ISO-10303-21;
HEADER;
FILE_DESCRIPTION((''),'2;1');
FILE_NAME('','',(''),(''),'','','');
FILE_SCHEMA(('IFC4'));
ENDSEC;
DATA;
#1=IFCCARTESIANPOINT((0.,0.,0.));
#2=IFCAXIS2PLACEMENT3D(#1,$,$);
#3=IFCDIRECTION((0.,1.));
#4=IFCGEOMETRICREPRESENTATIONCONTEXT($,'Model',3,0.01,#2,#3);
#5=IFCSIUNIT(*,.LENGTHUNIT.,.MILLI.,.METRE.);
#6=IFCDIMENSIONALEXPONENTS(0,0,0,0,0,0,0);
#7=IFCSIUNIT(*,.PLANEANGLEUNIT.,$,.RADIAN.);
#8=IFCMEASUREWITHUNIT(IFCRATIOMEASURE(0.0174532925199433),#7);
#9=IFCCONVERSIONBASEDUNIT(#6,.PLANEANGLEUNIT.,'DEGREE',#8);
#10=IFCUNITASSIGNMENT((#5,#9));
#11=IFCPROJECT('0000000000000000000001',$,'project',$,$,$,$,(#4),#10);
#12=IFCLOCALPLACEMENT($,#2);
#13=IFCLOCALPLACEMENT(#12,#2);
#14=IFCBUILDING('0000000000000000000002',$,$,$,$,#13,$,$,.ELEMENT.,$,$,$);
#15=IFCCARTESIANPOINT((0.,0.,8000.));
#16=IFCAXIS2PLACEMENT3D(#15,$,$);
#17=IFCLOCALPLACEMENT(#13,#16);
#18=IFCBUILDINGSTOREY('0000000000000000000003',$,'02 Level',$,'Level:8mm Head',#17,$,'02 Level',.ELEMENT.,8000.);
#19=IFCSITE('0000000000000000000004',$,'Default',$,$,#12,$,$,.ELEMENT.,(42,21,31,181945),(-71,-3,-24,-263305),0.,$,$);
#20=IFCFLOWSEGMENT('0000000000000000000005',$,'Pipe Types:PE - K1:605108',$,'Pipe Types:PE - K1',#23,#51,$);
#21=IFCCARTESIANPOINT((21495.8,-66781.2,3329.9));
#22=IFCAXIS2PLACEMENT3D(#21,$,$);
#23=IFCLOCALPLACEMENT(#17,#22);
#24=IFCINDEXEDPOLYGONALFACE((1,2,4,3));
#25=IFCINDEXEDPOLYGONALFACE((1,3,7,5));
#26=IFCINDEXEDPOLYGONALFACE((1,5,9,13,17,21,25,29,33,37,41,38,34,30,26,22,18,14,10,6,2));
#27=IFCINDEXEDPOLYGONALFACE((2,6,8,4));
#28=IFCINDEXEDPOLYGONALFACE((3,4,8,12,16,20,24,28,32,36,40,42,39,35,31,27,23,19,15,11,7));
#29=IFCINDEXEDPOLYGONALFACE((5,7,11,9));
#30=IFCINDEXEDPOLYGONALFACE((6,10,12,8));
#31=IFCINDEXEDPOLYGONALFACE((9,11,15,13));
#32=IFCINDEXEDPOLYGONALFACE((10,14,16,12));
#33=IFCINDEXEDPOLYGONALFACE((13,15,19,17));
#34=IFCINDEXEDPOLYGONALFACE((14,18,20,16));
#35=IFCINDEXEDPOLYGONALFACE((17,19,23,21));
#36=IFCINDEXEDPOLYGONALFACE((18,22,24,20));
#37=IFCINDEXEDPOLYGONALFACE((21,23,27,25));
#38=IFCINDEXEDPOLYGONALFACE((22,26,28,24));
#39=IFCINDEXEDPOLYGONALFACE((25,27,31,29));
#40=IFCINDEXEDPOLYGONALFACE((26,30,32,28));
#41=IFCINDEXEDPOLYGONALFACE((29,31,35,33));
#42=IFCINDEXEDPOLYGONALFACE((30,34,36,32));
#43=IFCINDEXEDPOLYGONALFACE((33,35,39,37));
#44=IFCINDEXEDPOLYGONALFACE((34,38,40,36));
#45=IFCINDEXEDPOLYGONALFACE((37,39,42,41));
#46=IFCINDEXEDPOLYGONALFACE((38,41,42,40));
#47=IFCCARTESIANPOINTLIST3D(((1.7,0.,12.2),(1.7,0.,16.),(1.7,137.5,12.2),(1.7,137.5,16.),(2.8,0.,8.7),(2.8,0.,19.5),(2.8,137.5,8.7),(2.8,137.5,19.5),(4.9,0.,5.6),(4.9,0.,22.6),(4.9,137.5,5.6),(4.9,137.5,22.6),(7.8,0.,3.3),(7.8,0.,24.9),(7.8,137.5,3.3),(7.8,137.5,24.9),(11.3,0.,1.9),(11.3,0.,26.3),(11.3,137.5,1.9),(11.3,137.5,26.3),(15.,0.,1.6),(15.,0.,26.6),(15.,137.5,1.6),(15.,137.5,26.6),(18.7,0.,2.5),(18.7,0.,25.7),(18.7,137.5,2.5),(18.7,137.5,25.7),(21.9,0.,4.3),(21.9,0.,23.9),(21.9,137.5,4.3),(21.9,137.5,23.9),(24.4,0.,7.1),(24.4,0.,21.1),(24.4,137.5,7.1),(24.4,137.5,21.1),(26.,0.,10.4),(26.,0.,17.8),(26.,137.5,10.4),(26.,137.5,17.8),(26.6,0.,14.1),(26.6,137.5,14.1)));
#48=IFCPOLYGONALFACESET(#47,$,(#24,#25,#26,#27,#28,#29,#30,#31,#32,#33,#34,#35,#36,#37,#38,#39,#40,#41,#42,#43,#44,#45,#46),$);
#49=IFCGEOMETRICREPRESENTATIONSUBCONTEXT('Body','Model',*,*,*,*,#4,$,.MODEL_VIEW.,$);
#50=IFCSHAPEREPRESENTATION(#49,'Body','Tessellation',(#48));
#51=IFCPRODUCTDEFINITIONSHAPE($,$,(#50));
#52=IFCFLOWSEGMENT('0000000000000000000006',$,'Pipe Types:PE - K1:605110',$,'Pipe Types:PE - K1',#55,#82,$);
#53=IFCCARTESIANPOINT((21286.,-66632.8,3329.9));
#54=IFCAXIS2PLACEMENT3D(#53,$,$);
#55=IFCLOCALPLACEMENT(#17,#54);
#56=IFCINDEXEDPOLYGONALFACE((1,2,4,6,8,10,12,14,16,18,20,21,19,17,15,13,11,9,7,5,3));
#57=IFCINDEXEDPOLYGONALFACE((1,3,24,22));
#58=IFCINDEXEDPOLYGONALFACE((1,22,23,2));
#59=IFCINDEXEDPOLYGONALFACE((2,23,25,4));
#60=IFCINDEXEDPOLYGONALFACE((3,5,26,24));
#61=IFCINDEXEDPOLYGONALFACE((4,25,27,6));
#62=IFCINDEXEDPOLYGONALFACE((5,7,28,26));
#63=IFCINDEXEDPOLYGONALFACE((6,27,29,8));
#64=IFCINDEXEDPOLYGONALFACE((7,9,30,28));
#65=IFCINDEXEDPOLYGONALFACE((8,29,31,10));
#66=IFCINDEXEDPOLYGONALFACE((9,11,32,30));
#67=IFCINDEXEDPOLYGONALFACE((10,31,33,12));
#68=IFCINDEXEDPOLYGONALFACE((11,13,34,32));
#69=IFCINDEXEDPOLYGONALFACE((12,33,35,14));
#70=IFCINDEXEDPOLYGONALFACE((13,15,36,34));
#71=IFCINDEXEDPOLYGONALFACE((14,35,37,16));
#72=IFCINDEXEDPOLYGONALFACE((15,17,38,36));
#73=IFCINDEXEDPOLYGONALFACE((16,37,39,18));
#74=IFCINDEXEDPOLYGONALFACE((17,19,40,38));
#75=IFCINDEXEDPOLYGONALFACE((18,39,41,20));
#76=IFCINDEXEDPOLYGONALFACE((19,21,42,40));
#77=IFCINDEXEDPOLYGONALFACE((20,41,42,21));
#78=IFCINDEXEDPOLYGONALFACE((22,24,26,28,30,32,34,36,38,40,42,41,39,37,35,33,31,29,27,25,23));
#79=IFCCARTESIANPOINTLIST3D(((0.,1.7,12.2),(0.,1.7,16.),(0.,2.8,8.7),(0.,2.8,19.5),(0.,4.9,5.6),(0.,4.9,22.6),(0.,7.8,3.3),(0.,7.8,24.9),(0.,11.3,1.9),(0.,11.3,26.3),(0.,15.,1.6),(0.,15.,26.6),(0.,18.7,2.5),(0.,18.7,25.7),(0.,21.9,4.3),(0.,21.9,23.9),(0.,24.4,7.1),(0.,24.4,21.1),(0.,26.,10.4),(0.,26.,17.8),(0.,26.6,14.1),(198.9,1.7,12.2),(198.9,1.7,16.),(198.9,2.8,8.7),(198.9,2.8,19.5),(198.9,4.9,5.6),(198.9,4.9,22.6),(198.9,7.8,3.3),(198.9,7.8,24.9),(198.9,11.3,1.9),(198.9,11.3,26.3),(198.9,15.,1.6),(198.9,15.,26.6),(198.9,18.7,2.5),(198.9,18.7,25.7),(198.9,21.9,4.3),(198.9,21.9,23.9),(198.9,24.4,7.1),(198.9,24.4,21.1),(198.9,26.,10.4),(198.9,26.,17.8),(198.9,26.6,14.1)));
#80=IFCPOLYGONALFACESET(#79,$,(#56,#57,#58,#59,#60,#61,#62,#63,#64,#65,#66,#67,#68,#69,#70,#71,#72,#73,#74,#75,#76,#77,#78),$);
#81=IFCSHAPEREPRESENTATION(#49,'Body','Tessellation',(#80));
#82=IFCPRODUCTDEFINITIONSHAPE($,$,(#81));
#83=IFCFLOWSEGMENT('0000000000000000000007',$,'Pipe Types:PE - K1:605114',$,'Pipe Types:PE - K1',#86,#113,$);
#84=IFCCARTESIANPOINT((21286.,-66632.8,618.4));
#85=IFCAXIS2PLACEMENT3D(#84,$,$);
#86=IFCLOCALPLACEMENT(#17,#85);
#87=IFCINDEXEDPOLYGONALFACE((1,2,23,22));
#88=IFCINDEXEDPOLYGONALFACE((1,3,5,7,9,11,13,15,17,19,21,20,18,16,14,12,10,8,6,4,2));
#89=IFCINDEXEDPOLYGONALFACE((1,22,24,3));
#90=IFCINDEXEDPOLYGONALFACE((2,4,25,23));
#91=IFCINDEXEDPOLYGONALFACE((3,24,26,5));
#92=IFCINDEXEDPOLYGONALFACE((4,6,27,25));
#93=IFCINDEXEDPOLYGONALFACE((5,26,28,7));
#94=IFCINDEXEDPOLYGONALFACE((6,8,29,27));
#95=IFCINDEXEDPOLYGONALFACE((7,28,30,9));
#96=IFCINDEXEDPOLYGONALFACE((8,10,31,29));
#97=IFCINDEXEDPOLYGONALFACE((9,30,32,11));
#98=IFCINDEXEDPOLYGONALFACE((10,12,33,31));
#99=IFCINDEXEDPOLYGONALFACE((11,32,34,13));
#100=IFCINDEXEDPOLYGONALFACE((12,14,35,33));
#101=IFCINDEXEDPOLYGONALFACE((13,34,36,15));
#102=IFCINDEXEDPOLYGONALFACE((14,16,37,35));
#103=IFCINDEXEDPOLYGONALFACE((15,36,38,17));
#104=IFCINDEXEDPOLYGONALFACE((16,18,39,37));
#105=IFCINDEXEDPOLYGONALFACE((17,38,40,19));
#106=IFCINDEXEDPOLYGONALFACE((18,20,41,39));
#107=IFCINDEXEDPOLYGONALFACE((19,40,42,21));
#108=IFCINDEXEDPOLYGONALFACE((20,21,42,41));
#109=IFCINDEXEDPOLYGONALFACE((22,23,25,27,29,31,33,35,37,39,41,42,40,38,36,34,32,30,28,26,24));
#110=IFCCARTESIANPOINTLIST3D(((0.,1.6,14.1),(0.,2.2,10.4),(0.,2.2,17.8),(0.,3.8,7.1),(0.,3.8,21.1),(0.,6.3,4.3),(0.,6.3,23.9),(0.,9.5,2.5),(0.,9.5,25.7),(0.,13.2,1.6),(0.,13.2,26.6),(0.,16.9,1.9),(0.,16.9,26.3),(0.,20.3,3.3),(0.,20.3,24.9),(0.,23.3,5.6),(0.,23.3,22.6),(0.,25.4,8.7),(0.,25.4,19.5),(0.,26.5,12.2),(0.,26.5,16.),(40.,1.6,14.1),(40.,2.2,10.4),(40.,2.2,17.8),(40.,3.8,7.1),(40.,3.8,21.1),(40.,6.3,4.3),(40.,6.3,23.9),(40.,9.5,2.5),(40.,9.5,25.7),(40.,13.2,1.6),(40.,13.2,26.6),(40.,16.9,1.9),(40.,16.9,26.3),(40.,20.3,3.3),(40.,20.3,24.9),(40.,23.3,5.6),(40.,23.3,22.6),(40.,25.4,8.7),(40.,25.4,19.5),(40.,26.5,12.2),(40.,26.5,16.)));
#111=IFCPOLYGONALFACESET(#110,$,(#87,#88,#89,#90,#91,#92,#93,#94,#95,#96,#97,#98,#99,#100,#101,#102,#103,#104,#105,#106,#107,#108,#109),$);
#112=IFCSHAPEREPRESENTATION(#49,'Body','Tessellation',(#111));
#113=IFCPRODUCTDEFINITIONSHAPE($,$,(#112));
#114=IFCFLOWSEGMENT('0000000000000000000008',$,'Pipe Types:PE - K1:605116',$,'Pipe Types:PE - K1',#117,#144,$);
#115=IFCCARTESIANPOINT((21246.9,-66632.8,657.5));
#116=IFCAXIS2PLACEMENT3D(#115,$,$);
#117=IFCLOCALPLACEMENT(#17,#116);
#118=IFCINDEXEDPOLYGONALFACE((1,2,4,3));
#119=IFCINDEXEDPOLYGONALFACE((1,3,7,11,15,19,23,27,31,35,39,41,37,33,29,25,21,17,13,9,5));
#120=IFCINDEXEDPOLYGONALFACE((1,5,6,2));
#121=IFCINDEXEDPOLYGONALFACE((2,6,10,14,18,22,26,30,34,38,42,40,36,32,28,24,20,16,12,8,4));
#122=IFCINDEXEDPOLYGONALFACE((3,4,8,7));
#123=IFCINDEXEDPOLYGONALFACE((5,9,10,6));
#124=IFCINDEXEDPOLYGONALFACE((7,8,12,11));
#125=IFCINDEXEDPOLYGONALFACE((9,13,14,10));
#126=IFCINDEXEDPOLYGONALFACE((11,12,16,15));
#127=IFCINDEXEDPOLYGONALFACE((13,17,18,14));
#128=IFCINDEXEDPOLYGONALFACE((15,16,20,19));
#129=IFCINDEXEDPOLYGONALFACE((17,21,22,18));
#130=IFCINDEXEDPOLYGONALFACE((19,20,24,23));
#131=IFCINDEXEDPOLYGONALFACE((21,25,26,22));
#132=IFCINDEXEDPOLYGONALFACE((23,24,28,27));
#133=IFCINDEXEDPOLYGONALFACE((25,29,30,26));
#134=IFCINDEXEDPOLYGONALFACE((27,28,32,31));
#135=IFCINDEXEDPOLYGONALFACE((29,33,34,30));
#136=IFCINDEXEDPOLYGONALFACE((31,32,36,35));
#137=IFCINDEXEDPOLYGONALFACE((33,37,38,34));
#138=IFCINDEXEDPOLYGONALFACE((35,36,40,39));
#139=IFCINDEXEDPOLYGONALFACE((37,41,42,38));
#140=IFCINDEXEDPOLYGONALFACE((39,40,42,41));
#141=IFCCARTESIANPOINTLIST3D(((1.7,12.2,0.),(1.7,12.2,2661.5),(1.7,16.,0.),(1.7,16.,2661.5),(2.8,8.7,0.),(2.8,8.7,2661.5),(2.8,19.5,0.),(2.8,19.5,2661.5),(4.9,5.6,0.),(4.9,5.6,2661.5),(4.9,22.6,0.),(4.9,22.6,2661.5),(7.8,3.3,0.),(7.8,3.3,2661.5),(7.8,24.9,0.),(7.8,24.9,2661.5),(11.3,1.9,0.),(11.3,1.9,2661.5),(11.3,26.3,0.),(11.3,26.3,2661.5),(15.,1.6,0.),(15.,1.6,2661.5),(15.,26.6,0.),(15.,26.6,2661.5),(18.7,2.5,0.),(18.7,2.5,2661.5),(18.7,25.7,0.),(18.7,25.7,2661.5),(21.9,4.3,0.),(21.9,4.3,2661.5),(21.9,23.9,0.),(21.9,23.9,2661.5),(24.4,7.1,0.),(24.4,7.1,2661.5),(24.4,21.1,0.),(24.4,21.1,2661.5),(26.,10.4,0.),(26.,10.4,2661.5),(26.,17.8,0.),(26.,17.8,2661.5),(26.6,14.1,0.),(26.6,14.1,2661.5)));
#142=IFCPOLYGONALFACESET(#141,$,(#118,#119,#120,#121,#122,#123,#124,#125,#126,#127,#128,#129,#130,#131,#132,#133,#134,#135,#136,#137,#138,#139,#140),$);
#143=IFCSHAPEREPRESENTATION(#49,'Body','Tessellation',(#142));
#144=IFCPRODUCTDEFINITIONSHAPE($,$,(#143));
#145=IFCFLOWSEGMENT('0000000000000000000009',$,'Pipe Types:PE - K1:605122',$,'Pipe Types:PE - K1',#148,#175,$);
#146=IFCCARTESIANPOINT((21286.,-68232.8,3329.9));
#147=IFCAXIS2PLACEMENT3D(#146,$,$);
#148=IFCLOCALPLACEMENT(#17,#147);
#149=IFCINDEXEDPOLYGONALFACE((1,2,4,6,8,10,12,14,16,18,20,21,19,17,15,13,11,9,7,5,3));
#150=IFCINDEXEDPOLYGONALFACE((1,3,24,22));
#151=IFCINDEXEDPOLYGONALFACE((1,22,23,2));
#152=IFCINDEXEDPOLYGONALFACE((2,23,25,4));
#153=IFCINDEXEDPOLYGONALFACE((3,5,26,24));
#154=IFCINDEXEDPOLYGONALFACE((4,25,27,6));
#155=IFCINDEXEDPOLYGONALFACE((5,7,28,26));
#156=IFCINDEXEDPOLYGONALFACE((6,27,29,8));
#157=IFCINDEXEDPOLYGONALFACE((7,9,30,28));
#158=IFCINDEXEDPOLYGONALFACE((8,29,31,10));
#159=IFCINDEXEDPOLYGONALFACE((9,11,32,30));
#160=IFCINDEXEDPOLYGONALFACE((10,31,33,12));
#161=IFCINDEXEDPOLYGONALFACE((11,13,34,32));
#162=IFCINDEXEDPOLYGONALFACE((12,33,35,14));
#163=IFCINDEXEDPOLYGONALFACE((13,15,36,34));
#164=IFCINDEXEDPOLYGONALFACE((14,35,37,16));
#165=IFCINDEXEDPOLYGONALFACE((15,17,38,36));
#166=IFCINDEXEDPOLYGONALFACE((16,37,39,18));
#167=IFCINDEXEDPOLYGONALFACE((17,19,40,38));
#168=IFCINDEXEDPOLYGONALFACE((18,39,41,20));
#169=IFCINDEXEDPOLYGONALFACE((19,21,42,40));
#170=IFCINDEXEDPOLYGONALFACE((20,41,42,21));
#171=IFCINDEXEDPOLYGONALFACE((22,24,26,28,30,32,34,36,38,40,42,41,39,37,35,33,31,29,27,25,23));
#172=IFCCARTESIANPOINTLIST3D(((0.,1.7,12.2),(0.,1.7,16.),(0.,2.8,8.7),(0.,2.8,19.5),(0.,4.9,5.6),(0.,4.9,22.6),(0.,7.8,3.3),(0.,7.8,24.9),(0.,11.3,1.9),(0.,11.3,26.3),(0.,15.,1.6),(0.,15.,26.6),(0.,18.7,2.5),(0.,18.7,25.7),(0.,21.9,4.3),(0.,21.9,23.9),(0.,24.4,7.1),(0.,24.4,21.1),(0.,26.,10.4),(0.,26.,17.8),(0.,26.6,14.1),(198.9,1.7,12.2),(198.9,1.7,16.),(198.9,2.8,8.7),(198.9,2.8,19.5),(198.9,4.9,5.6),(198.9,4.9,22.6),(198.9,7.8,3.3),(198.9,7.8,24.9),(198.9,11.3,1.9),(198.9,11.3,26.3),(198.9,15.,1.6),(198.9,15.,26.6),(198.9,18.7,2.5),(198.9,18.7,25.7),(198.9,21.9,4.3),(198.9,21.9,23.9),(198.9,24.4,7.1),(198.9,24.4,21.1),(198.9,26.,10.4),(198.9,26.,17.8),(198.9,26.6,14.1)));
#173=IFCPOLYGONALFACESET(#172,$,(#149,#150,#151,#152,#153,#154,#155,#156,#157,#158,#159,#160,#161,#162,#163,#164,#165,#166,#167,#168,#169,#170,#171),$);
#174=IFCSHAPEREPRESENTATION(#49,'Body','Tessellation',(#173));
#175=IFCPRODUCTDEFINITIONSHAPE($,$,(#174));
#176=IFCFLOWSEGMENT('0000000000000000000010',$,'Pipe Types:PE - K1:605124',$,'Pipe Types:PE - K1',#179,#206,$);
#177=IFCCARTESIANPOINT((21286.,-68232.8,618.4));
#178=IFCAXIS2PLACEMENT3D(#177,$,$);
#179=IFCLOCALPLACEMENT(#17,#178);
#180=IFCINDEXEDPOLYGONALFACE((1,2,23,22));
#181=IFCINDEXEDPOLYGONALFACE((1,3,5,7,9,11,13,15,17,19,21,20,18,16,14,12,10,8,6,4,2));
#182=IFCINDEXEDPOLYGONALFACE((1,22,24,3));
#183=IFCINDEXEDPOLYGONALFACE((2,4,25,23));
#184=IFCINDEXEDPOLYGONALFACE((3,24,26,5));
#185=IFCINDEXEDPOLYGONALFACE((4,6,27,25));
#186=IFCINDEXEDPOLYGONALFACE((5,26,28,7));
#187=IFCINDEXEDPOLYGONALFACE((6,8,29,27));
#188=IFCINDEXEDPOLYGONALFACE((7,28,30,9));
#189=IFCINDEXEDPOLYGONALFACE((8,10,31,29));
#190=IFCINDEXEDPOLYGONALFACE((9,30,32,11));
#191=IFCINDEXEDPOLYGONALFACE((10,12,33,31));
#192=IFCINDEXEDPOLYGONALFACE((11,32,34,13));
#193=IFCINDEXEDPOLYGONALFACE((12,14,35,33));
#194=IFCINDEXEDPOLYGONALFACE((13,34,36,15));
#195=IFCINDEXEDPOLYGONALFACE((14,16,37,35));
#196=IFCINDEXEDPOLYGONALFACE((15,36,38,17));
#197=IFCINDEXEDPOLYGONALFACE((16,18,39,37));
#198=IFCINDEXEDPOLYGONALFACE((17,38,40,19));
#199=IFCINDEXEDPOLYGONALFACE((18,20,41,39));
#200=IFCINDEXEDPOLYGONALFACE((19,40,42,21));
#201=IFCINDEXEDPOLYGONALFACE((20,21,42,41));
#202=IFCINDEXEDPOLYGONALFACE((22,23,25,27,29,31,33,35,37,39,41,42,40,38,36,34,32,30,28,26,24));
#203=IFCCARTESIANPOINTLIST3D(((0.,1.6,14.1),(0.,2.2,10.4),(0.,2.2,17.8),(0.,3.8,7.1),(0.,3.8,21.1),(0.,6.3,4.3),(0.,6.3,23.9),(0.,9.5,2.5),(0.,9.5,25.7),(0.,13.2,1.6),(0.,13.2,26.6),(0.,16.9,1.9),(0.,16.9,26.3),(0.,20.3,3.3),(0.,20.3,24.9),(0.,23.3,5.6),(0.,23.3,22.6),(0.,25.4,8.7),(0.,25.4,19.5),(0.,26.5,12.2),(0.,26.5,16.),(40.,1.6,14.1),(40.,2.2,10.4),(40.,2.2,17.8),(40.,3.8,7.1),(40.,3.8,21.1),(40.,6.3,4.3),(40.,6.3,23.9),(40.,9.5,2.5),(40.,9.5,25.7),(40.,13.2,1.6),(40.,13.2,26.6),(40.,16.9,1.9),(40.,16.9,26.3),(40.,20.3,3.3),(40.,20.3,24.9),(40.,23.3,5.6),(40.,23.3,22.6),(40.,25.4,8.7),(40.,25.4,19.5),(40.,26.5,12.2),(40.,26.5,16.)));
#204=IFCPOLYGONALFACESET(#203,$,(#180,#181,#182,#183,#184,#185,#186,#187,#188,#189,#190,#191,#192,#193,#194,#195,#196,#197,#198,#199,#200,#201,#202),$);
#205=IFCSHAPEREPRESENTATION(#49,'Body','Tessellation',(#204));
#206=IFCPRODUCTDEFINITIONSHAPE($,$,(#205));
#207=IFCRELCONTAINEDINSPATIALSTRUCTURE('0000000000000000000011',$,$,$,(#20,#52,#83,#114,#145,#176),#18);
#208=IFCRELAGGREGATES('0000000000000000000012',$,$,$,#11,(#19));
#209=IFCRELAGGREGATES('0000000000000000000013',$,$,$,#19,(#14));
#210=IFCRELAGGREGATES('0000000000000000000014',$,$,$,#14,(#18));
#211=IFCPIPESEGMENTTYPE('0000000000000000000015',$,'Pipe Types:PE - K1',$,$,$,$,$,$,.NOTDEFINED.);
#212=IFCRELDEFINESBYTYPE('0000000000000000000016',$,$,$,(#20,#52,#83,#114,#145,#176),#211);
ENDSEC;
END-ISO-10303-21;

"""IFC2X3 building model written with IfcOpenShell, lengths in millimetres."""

from ifc_helpers import new_model, entity, si_unit, converted_unit, direction, frame, frame_2d, origin, origin_2d_with_axis, place, context, subcontext, project, spatial, circle, extrude, type_object, element, save


model = new_model("IFC2X3")

# Units and contexts
model_context = context("Model", 3, precision=0.01, world=origin(), true_north=direction((0.0, 1.0)))
body_context = subcontext(model_context, "Body", "Model", "MODEL_VIEW")
ifc_project = project(units=[si_unit("LENGTHUNIT", "METRE", prefix="MILLI"), converted_unit("PLANEANGLEUNIT", "DEGREE", entity("IfcRatioMeasure", 0.0174532925199433), si_unit("PLANEANGLEUNIT", "RADIAN"), dimensions=[0, 0, 0, 0, 0, 0, 0])], contexts=[model_context])

# Site, building, storey
site_placement = place(None, origin())
site = spatial("IfcSite", under=ifc_project, at=site_placement, Name="Default", CompositionType="ELEMENT", RefLatitude=(42, 21, 31, 181945), RefLongitude=(-71, -3, -24, -263305), RefElevation=0.0)
building_placement = place(site_placement, origin())
building = spatial("IfcBuilding", under=site, at=building_placement, CompositionType="ELEMENT")
storey_placement = place(building_placement, frame((0.0, 0.0, 8000.0)))
storey = spatial("IfcBuildingStorey", under=building, at=storey_placement, Name="02 Level", ObjectType="Level:8mm Head", LongName="02 Level", CompositionType="ELEMENT", Elevation=8000.0)

# Flow segments
pipe_segment_type = type_object("IfcPipeSegmentType", Name="Pipe Types:PE - K1", PredefinedType="NOTDEFINED")
flow_segment_1_placement = place(storey_placement, frame((21495.8, -66781.2, 3329.9)))
element("IfcFlowSegment", 1, at=flow_segment_1_placement, inside=storey, type_object=pipe_segment_type, Name="Pipe Types:PE - K1:605108", ObjectType="Pipe Types:PE - K1", context=body_context, shape_type="SweptSolid", body=[
    extrude(circle(Radius=12.5, at=origin_2d_with_axis()), frame((14.1, 0.0, 14.1), z_axis=(0.0, 1.0, 0.0), x_axis=(1.0, 0.0, 0.0)), (0.0, 0.0, 1.0), 137.5),
])
flow_segment_2_placement = place(storey_placement, frame((21286.0, -66632.8, 3329.9)))
element("IfcFlowSegment", 2, at=flow_segment_2_placement, inside=storey, type_object=pipe_segment_type, Name="Pipe Types:PE - K1:605110", ObjectType="Pipe Types:PE - K1", context=body_context, shape_type="SweptSolid", body=[
    extrude(circle(Radius=12.5, at=frame_2d((0.0, 0.0), x_axis=(1.0, 0.0))), frame((0.0, 14.1, 14.1), z_axis=(1.0, 0.0, 0.0), x_axis=(0.0, 1.0, 0.0)), (0.0, 0.0, 1.0), 198.9),
])
flow_segment_3_placement = place(storey_placement, frame((21286.0, -66632.8, 618.4)))
element("IfcFlowSegment", 3, at=flow_segment_3_placement, inside=storey, type_object=pipe_segment_type, Name="Pipe Types:PE - K1:605114", ObjectType="Pipe Types:PE - K1", context=body_context, shape_type="SweptSolid", body=[
    extrude(circle(Radius=12.5, at=frame_2d((0.0, 0.0), x_axis=(1.0, 0.0))), frame((0.0, 14.1, 14.1), z_axis=(1.0, 0.0, 0.0), x_axis=(0.0, -1.0, 0.0)), (0.0, 0.0, 1.0), 40.0),
])
flow_segment_4_placement = place(storey_placement, frame((21246.9, -66632.8, 657.5)))
element("IfcFlowSegment", 4, at=flow_segment_4_placement, inside=storey, type_object=pipe_segment_type, Name="Pipe Types:PE - K1:605116", ObjectType="Pipe Types:PE - K1", context=body_context, shape_type="SweptSolid", body=[
    extrude(circle(Radius=12.5, at=origin_2d_with_axis()), frame((14.1, 14.1, 0.0)), (0.0, 0.0, 1.0), 2661.5),
])
flow_segment_5_placement = place(storey_placement, frame((21286.0, -68232.8, 3329.9)))
element("IfcFlowSegment", 5, at=flow_segment_5_placement, inside=storey, type_object=pipe_segment_type, Name="Pipe Types:PE - K1:605122", ObjectType="Pipe Types:PE - K1", context=body_context, shape_type="SweptSolid", body=[
    extrude(circle(Radius=12.5, at=frame_2d((0.0, 0.0), x_axis=(1.0, 0.0))), frame((0.0, 14.1, 14.1), z_axis=(1.0, 0.0, 0.0), x_axis=(0.0, 1.0, 0.0)), (0.0, 0.0, 1.0), 198.9),
])
flow_segment_6_placement = place(storey_placement, frame((21286.0, -68232.8, 618.4)))
element("IfcFlowSegment", 6, at=flow_segment_6_placement, inside=storey, type_object=pipe_segment_type, Name="Pipe Types:PE - K1:605124", ObjectType="Pipe Types:PE - K1", context=body_context, shape_type="SweptSolid", body=[
    extrude(circle(Radius=12.5, at=frame_2d((0.0, 0.0), x_axis=(1.0, 0.0))), frame((0.0, 14.1, 14.1), z_axis=(1.0, 0.0, 0.0), x_axis=(0.0, -1.0, 0.0)), (0.0, 0.0, 1.0), 40.0),
])

save(model, "model.ifc")
